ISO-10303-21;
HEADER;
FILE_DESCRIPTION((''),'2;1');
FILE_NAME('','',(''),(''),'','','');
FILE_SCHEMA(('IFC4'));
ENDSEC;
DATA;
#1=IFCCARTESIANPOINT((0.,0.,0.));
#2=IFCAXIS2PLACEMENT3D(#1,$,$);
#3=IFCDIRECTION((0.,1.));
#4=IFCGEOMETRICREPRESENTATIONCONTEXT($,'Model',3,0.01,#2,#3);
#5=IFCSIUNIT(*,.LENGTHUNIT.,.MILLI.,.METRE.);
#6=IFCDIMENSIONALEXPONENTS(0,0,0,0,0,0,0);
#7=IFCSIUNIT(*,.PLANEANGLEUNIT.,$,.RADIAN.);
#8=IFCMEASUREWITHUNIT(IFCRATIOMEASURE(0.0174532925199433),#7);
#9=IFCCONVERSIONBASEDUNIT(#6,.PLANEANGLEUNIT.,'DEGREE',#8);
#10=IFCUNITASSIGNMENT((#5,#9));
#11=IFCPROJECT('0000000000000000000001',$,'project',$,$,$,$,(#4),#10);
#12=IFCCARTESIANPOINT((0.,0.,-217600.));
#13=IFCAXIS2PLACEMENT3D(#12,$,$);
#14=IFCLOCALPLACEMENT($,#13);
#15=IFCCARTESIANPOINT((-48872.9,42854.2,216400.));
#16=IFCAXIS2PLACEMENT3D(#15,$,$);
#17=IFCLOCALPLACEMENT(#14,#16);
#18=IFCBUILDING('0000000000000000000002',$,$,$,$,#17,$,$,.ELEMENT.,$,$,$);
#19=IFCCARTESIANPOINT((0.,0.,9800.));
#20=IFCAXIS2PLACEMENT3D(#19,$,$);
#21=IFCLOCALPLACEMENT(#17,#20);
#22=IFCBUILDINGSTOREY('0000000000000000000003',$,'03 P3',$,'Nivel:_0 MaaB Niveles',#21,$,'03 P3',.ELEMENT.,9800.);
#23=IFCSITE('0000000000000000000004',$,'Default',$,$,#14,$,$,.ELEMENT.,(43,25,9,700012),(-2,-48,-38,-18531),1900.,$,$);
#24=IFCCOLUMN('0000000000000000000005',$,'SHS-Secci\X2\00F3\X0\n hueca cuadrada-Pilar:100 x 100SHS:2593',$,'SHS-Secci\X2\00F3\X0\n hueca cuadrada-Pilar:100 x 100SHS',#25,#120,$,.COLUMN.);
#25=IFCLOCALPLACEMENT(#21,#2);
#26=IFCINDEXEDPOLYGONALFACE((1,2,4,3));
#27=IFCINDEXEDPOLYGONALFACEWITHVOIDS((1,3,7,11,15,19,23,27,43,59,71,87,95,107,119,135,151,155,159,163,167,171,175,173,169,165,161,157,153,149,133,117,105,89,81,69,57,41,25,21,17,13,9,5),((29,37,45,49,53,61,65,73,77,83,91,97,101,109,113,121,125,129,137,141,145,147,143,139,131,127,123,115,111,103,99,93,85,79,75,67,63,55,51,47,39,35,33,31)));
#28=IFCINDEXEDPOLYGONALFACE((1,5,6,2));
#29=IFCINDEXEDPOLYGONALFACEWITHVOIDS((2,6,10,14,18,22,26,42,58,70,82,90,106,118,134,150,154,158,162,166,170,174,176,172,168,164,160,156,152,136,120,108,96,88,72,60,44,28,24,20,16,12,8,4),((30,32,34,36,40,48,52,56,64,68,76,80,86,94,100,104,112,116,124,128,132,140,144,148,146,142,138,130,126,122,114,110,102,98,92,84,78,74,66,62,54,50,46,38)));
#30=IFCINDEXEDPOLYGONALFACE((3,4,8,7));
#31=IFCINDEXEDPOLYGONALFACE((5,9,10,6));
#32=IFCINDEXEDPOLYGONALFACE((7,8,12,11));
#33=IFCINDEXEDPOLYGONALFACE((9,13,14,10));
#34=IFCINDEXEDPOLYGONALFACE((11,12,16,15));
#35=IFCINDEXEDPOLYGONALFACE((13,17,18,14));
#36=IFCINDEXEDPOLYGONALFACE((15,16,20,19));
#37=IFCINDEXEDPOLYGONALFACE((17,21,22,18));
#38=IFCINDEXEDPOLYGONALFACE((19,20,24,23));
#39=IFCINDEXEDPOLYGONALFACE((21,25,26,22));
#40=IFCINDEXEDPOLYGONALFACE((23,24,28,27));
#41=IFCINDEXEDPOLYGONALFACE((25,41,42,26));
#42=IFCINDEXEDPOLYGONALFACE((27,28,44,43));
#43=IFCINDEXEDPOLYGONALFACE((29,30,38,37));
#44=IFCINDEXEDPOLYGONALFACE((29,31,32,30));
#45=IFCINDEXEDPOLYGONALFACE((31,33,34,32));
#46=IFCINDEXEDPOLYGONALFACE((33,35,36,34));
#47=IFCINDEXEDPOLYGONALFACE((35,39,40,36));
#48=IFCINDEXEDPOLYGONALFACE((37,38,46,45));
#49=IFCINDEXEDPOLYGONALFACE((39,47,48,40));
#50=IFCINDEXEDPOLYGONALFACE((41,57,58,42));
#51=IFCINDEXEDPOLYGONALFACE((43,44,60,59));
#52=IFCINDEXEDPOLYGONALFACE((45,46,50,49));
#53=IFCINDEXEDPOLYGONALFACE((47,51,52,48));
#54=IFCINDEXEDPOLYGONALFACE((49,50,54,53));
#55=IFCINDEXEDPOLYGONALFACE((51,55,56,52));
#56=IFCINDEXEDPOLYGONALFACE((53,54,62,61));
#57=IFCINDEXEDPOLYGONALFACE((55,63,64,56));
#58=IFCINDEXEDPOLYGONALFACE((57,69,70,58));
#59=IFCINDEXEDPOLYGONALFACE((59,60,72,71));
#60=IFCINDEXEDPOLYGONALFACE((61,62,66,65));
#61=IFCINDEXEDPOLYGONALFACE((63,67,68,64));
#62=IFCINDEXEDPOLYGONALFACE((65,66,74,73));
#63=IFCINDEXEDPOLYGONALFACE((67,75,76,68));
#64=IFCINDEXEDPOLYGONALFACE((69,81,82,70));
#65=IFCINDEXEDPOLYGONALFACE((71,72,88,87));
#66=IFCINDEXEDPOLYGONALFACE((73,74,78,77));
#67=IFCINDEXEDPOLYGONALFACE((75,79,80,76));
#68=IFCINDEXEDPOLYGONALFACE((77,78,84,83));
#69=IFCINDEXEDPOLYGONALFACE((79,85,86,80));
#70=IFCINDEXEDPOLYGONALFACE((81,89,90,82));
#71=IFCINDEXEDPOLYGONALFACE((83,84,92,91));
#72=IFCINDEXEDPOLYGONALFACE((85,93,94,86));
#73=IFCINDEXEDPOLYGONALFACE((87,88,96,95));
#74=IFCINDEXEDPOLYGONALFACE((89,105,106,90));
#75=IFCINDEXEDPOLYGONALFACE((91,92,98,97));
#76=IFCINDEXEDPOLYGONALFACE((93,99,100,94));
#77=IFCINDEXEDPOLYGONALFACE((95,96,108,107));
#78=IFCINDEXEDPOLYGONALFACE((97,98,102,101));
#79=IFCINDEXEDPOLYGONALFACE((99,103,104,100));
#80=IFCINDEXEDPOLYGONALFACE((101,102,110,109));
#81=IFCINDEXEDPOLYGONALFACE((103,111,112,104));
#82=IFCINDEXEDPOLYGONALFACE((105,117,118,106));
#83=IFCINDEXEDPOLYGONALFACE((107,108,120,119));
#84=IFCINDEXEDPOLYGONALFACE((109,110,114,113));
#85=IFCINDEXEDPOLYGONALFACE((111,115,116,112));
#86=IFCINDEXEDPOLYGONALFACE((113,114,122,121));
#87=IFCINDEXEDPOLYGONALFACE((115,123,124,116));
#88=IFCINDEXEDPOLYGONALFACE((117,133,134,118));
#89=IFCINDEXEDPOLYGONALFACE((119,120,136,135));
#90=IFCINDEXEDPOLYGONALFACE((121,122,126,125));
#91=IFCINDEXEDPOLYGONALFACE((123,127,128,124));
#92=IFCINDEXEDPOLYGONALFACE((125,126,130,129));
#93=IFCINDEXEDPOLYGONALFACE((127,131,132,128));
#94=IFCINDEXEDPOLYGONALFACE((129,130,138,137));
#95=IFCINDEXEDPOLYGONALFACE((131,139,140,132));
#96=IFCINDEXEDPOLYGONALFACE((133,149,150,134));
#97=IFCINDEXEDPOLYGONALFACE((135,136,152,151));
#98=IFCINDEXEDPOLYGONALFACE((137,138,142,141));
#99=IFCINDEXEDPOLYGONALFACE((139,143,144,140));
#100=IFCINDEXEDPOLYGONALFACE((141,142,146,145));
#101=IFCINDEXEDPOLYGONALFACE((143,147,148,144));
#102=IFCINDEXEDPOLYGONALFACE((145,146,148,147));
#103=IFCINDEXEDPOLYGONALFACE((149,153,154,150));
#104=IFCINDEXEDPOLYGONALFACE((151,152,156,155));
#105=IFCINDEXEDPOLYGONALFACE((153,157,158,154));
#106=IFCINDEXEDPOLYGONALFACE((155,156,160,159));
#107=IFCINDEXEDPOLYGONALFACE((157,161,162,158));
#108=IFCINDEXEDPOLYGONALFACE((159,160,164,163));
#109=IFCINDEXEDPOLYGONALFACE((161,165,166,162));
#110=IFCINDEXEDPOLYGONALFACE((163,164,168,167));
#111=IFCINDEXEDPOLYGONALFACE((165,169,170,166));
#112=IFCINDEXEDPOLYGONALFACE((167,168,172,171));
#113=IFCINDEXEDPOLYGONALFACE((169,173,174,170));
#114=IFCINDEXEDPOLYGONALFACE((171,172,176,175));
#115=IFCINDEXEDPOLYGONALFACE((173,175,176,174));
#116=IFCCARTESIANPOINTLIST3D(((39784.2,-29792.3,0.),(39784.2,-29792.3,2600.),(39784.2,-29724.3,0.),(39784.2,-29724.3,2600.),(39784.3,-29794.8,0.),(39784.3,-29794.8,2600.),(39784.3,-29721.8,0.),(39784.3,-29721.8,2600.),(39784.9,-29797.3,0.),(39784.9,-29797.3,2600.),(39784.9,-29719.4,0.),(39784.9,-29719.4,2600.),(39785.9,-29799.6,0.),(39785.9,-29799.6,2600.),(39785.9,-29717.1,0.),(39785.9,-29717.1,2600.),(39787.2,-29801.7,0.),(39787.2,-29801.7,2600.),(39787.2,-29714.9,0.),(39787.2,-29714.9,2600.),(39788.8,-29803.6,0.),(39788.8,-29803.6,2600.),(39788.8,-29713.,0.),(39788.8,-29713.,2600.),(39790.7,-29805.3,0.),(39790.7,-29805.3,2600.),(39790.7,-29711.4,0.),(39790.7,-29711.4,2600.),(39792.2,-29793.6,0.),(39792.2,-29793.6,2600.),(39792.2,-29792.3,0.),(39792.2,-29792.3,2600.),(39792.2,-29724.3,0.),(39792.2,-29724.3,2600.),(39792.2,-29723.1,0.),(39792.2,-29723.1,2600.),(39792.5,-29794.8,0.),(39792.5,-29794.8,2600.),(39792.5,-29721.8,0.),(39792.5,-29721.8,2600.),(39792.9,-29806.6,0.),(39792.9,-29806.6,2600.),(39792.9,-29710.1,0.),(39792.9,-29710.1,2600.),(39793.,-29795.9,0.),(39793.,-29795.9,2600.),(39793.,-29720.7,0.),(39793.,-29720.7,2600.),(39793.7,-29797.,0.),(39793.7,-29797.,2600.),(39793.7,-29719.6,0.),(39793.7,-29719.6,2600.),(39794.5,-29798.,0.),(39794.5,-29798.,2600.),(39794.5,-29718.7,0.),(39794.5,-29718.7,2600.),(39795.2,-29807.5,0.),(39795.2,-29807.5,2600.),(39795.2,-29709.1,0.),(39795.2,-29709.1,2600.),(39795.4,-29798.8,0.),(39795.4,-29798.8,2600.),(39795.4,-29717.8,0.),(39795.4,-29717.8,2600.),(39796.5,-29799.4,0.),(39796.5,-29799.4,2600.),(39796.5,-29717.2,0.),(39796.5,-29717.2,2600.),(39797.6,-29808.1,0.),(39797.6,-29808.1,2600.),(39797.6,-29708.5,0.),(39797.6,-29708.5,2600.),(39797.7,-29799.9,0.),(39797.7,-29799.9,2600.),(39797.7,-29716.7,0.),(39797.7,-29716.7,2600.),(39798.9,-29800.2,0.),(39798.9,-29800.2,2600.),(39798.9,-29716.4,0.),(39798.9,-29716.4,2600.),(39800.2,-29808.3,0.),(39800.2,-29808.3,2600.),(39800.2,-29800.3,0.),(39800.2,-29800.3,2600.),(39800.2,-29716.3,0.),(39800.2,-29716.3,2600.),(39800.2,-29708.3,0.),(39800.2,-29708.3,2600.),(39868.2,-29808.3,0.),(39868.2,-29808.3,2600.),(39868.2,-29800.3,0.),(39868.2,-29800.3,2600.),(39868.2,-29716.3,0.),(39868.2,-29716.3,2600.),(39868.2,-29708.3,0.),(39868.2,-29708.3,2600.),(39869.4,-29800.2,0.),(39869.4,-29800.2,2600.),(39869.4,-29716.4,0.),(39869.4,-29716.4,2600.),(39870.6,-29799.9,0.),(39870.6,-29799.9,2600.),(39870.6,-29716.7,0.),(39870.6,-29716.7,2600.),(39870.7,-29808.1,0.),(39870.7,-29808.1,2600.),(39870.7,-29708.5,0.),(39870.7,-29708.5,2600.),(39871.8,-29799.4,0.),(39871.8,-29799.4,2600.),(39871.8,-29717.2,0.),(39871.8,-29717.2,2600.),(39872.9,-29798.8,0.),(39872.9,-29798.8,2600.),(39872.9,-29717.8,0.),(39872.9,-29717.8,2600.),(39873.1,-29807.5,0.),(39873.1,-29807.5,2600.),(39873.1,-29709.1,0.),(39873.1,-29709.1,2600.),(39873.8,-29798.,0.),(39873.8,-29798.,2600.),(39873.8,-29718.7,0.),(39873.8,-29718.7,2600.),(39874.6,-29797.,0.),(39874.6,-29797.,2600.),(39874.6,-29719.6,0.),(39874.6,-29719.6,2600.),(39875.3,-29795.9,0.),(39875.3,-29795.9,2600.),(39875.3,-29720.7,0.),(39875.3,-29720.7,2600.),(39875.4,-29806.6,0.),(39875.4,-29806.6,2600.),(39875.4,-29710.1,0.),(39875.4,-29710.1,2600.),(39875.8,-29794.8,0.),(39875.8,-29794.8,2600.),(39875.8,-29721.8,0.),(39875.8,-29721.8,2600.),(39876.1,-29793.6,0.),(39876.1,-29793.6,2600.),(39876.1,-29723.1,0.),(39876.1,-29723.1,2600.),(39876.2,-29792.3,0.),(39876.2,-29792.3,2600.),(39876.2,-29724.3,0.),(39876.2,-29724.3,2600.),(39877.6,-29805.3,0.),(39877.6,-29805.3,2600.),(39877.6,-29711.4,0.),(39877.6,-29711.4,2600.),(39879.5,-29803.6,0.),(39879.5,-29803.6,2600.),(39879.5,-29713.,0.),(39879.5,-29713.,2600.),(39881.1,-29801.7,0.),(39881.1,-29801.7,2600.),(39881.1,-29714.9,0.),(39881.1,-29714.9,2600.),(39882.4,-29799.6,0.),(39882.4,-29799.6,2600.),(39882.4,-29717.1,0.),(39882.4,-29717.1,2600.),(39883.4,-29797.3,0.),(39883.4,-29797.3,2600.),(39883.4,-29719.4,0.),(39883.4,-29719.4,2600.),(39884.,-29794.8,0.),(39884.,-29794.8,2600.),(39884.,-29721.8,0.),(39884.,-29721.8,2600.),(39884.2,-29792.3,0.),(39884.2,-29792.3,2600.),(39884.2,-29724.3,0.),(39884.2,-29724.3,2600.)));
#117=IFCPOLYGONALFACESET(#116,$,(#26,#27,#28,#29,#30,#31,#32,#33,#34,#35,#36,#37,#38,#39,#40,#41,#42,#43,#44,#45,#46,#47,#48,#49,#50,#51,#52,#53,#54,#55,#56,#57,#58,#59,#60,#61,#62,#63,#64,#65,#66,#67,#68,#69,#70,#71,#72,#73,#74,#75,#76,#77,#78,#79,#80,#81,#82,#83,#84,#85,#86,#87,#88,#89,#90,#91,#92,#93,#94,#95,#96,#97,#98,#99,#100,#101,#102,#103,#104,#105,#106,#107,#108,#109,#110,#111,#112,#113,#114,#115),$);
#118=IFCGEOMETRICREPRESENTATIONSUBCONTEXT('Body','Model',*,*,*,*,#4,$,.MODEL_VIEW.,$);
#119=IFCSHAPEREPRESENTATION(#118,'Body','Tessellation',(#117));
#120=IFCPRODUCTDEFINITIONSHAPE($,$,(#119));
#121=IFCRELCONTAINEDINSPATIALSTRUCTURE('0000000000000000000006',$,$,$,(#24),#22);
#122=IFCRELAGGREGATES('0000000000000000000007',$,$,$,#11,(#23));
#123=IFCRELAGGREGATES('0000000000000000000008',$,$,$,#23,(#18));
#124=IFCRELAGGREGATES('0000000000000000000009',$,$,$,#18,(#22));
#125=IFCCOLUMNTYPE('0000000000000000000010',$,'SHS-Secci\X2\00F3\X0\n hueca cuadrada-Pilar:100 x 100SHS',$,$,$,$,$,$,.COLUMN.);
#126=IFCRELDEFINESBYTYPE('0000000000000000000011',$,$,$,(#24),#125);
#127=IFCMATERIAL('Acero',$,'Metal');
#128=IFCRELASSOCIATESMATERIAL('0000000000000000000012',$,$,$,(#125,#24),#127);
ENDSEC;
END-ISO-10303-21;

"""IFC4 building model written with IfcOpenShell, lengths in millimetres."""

from ifc_helpers import new_model, entity, si_unit, converted_unit, direction, frame, origin, place, context, subcontext, project, spatial, indexed_curve, outline, extrude, source, transform, mapped, material, type_object, type_shapes, element, save


model = new_model("IFC4")

# Units and contexts
model_context = context("Model", 3, precision=0.01, world=origin(), true_north=direction((0.0, 1.0)))
body_context = subcontext(model_context, "Body", "Model", "MODEL_VIEW")
ifc_project = project(units=[si_unit("LENGTHUNIT", "METRE", prefix="MILLI"), converted_unit("PLANEANGLEUNIT", "DEGREE", entity("IfcRatioMeasure", 0.0174532925199433), si_unit("PLANEANGLEUNIT", "RADIAN"), dimensions=[0, 0, 0, 0, 0, 0, 0])], contexts=[model_context])

# Site, building, storey
site_placement = place(None, frame((0.0, 0.0, -217600.0)))
site = spatial("IfcSite", under=ifc_project, at=site_placement, Name="Default", CompositionType="ELEMENT", RefLatitude=(43, 25, 9, 700012), RefLongitude=(-2, -48, -38, -18531), RefElevation=1900.0)
building_placement = place(site_placement, frame((-48872.9, 42854.2, 216400.0)))
building = spatial("IfcBuilding", under=site, at=building_placement, CompositionType="ELEMENT")
storey_placement = place(building_placement, frame((0.0, 0.0, 9800.0)))
storey = spatial("IfcBuildingStorey", under=building, at=storey_placement, Name="03 P3", ObjectType="Nivel:_0 MaaB Niveles", LongName="03 P3", CompositionType="ELEMENT", Elevation=9800.0)

# Column
ifc_material_1 = material(Name="Acero", Category="Metal")
column_type_1 = type_object("IfcColumnType", Name="SHS-Sección hueca cuadrada-Pilar:100 x 100SHS", PredefinedType="COLUMN", material=ifc_material_1)
shared_shape_1 = source(origin(), body_context, "Body", "SweptSolid", [
    extrude(outline(indexed_curve([(-34.0, -50.0), (34.0, -50.0), (36.5, -49.8), (38.9, -49.2), (41.3, -48.3), (43.4, -46.9), (45.3, -45.3), (46.9, -43.4), (48.3, -41.3), (49.2, -38.9), (49.8, -36.5), (50.0, -34.0), (50.0, 34.0), (49.8, 36.5), (49.2, 38.9), (48.3, 41.3), (46.9, 43.4), (45.3, 45.3), (43.4, 46.9), (41.3, 48.3), (38.9, 49.2), (36.5, 49.8), (34.0, 50.0), (-34.0, 50.0), (-36.5, 49.8), (-38.9, 49.2), (-41.3, 48.3), (-43.4, 46.9), (-45.3, 45.3), (-46.9, 43.4), (-48.3, 41.3), (-49.2, 38.9), (-49.8, 36.5), (-50.0, 34.0), (-50.0, -34.0), (-49.8, -36.5), (-49.2, -38.9), (-48.3, -41.3), (-46.9, -43.4), (-45.3, -45.3), (-43.4, -46.9), (-41.3, -48.3), (-38.9, -49.2), (-36.5, -49.8), (-34.0, -50.0)], self_intersect=False), holes=[indexed_curve([(-34.0, -42.0), (-35.3, -41.9), (-36.5, -41.6), (-37.6, -41.1), (-38.7, -40.5), (-39.7, -39.7), (-40.5, -38.7), (-41.1, -37.6), (-41.6, -36.5), (-41.9, -35.3), (-42.0, -34.0), (-42.0, 34.0), (-41.9, 35.3), (-41.6, 36.5), (-41.1, 37.6), (-40.5, 38.7), (-39.7, 39.7), (-38.7, 40.5), (-37.6, 41.1), (-36.5, 41.6), (-35.3, 41.9), (-34.0, 42.0), (34.0, 42.0), (35.3, 41.9), (36.5, 41.6), (37.6, 41.1), (38.7, 40.5), (39.7, 39.7), (40.5, 38.7), (41.1, 37.6), (41.6, 36.5), (41.9, 35.3), (42.0, 34.0), (42.0, -34.0), (41.9, -35.3), (41.6, -36.5), (41.1, -37.6), (40.5, -38.7), (39.7, -39.7), (38.7, -40.5), (37.6, -41.1), (36.5, -41.6), (35.3, -41.9), (34.0, -42.0), (-34.0, -42.0)], self_intersect=False)]), frame((0.0, 0.0, 9800.0), z_axis=(0.0, 0.0, 1.0), x_axis=(-1.0, 0.0, 0.0)), (0.0, 0.0, 1.0), 2600.0),
])
type_shapes(column_type_1, [shared_shape_1])
column_1_placement = place(storey_placement, frame((39834.2, -29758.3, -9800.0), z_axis=(0.0, 0.0, 1.0), x_axis=(0.0, -1.0, 0.0)))
element("IfcColumn", 1, at=column_1_placement, inside=storey, type_object=column_type_1, material=ifc_material_1, Name="SHS-Sección hueca cuadrada-Pilar:100 x 100SHS:2593", ObjectType="SHS-Sección hueca cuadrada-Pilar:100 x 100SHS", PredefinedType="COLUMN", context=body_context, shape_type="MappedRepresentation", body=[
    mapped(shared_shape_1, transform((0.0, 0.0, 0.0), scale=1.0)),
])

save(model, "model.ifc")
